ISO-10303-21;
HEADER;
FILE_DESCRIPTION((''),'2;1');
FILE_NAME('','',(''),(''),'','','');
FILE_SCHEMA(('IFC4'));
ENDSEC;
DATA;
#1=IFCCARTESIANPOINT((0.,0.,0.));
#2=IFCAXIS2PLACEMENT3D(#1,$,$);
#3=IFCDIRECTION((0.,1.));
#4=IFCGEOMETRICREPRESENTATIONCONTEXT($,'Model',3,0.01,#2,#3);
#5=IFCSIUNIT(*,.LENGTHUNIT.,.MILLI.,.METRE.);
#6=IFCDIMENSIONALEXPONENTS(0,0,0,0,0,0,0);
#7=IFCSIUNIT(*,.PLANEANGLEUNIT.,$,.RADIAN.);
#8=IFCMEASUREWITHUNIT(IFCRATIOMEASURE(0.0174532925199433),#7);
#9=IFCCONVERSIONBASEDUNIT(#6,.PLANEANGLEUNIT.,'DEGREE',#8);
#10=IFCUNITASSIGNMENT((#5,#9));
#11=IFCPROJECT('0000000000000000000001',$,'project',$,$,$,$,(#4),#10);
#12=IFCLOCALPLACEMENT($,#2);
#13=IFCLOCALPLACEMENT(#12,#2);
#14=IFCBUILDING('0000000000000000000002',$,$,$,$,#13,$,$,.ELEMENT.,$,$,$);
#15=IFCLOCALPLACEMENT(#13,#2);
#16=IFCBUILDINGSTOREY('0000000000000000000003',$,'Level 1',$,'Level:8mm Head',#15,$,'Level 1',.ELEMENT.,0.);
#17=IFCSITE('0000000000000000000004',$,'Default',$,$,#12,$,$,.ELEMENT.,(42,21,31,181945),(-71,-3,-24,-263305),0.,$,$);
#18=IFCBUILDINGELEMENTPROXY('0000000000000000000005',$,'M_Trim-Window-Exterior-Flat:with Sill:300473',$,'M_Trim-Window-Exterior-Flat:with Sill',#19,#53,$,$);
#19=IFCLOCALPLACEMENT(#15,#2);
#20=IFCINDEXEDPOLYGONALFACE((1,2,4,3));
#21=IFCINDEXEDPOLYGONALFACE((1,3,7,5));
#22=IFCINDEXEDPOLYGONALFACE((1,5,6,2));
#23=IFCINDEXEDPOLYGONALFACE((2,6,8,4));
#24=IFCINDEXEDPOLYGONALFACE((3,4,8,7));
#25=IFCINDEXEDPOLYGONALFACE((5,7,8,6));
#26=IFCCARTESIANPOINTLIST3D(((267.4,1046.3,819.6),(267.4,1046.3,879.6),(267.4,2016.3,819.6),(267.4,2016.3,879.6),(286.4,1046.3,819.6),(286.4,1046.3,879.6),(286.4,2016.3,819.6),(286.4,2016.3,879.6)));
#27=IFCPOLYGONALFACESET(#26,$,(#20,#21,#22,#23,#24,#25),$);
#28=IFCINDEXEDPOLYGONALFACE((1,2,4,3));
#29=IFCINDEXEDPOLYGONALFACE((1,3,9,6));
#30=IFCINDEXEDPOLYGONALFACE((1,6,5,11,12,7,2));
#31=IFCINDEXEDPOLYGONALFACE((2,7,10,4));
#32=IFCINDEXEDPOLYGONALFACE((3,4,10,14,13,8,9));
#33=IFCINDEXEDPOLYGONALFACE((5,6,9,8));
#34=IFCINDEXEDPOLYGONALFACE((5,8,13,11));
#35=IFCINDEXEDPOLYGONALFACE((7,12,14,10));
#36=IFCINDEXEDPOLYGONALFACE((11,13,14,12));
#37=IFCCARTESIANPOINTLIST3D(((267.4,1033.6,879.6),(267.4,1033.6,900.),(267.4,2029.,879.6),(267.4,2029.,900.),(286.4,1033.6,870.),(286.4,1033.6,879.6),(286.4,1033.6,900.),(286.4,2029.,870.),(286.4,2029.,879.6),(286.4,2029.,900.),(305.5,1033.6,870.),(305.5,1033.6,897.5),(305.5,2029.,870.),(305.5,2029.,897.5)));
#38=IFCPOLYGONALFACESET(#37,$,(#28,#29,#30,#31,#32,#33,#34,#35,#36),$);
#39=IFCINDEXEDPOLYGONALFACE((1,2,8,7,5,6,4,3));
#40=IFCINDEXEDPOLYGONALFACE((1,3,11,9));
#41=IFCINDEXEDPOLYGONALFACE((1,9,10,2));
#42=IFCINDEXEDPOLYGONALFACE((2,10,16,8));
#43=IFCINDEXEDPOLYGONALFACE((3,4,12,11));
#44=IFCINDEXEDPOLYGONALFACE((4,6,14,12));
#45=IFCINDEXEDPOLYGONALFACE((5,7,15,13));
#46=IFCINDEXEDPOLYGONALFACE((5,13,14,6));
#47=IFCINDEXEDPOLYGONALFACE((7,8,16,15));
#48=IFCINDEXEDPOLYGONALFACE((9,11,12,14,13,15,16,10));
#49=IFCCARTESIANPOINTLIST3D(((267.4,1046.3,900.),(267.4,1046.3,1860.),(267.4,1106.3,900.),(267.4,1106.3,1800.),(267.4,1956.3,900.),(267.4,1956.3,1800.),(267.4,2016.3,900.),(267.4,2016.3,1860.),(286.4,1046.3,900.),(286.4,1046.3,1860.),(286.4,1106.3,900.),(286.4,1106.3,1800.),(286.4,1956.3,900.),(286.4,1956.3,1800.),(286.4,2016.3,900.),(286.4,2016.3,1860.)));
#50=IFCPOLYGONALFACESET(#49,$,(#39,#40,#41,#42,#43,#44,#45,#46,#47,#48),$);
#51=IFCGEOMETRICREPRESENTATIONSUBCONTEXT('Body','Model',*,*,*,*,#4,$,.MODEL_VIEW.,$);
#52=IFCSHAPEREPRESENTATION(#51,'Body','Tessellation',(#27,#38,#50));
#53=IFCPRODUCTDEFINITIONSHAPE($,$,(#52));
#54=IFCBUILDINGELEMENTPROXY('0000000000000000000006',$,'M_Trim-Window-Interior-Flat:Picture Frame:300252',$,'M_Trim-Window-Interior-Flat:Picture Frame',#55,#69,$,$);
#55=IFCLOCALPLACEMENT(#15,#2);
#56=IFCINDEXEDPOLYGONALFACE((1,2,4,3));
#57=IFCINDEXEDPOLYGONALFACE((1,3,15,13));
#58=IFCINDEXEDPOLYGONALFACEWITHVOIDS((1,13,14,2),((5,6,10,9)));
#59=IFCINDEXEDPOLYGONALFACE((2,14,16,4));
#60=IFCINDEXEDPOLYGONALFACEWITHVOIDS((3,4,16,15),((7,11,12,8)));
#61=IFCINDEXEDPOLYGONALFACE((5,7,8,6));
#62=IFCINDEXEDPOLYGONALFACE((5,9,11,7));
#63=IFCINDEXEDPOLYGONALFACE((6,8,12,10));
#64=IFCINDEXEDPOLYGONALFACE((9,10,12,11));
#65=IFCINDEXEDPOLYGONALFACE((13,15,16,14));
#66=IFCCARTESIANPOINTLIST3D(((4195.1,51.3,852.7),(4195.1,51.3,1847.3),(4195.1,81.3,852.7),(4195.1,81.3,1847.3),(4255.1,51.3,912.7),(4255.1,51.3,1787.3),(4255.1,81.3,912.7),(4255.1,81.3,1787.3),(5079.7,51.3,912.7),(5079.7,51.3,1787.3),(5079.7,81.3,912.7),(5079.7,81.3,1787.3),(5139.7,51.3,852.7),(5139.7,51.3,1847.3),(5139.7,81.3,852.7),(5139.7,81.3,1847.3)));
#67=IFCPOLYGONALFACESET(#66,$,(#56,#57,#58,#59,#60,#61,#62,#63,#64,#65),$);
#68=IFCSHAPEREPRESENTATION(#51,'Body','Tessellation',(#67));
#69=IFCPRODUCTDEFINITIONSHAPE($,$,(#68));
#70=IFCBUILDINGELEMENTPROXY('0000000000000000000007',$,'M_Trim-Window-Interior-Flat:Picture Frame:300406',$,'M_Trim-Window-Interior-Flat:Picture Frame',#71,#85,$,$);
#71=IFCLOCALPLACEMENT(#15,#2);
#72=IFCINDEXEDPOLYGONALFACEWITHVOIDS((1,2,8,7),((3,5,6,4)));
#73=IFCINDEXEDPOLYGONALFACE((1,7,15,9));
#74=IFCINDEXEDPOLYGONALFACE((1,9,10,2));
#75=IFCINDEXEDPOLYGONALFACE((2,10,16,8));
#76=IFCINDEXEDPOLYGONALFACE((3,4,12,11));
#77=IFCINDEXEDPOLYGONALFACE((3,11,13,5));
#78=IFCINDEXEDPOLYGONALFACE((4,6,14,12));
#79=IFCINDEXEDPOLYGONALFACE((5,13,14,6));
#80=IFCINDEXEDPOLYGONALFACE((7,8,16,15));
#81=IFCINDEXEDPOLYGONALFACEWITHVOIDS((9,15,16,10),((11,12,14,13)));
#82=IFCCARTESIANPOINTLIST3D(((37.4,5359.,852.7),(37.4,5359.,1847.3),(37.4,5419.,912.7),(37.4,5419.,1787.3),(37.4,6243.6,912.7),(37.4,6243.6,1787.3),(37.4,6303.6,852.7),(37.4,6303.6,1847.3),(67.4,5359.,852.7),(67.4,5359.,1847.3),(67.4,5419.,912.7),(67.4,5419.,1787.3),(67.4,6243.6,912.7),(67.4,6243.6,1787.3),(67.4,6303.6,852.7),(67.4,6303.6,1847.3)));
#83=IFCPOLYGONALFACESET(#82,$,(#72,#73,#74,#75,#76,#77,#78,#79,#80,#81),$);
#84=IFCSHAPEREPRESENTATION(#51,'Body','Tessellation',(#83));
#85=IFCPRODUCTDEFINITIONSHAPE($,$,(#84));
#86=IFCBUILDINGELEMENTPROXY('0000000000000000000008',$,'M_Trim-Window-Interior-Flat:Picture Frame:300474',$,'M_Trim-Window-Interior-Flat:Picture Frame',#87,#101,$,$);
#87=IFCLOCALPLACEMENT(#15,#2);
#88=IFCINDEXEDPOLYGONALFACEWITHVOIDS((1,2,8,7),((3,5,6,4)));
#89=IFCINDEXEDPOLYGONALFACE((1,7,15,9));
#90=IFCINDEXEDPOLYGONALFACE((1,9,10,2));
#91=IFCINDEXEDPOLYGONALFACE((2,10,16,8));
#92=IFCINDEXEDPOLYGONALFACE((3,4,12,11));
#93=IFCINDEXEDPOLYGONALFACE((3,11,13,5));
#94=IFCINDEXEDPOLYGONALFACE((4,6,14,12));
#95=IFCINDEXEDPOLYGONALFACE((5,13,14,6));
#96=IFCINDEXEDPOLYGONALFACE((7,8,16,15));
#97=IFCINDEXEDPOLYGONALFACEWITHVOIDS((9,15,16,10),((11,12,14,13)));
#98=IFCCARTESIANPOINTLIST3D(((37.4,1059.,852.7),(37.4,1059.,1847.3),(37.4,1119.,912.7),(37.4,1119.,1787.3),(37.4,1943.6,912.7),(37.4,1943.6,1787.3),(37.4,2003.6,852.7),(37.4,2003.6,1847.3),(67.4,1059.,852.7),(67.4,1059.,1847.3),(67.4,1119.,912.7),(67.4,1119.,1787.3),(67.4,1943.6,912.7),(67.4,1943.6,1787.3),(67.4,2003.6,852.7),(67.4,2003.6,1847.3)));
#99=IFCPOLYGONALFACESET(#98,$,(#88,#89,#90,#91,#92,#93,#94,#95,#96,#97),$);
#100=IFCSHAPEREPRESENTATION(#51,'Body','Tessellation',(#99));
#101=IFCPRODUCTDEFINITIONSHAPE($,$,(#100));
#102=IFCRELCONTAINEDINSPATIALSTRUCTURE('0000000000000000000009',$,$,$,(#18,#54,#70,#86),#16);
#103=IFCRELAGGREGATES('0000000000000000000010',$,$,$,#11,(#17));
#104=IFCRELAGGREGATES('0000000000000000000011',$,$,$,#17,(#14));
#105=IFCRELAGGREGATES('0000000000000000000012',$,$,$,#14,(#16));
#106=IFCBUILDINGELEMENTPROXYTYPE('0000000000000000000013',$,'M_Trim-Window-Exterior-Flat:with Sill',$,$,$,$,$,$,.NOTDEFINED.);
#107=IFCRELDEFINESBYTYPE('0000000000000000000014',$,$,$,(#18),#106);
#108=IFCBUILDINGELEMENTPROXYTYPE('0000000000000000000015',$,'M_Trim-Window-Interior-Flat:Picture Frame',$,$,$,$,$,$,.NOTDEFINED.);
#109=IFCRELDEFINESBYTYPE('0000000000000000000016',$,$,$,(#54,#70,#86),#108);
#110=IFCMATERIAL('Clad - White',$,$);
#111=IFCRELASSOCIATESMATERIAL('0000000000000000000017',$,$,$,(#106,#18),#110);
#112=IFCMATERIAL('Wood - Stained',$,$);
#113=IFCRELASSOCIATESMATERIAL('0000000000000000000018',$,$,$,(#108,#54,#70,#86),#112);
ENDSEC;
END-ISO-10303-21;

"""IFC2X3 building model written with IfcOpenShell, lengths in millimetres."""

from ifc_helpers import new_model, entity, si_unit, converted_unit, direction, frame, frame_2d, origin, place, context, subcontext, project, spatial, polyline, rectangle, outline, extrude, source, transform, mapped, material, type_object, type_shapes, element, save


model = new_model("IFC2X3")

# Units and contexts
model_context = context("Model", 3, precision=0.01, world=origin(), true_north=direction((0.0, 1.0)))
body_context = subcontext(model_context, "Body", "Model", "MODEL_VIEW")
ifc_project = project(units=[si_unit("LENGTHUNIT", "METRE", prefix="MILLI"), converted_unit("PLANEANGLEUNIT", "DEGREE", entity("IfcRatioMeasure", 0.0174532925199433), si_unit("PLANEANGLEUNIT", "RADIAN"), dimensions=[0, 0, 0, 0, 0, 0, 0])], contexts=[model_context])

# Site, building, storey
site_placement = place(None, origin())
site = spatial("IfcSite", under=ifc_project, at=site_placement, Name="Default", CompositionType="ELEMENT", RefLatitude=(42, 21, 31, 181945), RefLongitude=(-71, -3, -24, -263305), RefElevation=0.0)
building_placement = place(site_placement, origin())
building = spatial("IfcBuilding", under=site, at=building_placement, CompositionType="ELEMENT")
storey_placement = place(building_placement, origin())
storey = spatial("IfcBuildingStorey", under=building, at=storey_placement, Name="Level 1", ObjectType="Level:8mm Head", LongName="Level 1", CompositionType="ELEMENT", Elevation=0.0)

# Building element proxies
ifc_material_1 = material(Name="Clad - White")
ifc_material_2 = material(Name="Wood - Stained")
building_element_proxy_type_1 = type_object("IfcBuildingElementProxyType", Name="M_Trim-Window-Exterior-Flat:with Sill", PredefinedType="NOTDEFINED", material=ifc_material_1)
shared_shape_1 = source(origin(), body_context, "Body", "SweptSolid", [
    extrude(rectangle(XDim=970.0, YDim=60.0, at=frame_2d((0.0, 0.0), x_axis=(1.0, 0.0))), frame((0.0, -950.4, 0.0), z_axis=(0.0, 0.0, 1.0), x_axis=(-1.0, 0.0, 0.0)), (0.0, 0.0, 1.0), 19.1),
    extrude(outline(polyline([(-19.0, -15.2), (0.0, -15.2), (0.0, -5.7), (19.0, -5.7), (19.0, 14.8), (0.0, 14.8), (-19.0, 12.3), (-19.0, -15.2)])), frame((-497.7, -914.8, 19.0), z_axis=(1.0, 0.0, 0.0), x_axis=(0.0, 0.0, -1.0)), (0.0, 0.0, 1.0), 995.4),
    extrude(outline(polyline([(-495.0, -485.0), (465.0, -485.0), (465.0, -425.0), (-435.0, -425.0), (-435.0, 425.0), (465.0, 425.0), (465.0, 485.0), (-495.0, 485.0), (-495.0, -485.0)])), frame((0.0, -435.0, 0.0), z_axis=(0.0, 0.0, 1.0), x_axis=(0.0, -1.0, 0.0)), (0.0, 0.0, 1.0), 19.1),
])
type_shapes(building_element_proxy_type_1, [shared_shape_1])
for number, where, z_axis, x_axis, name in (
    (1, (267.4, 1531.3, 1800.0), (1.0, 0.0, 0.0), (0.0, 1.0, 0.0), "M_Trim-Window-Exterior-Flat:with Sill:300473"),
):
    element("IfcBuildingElementProxy", number, at=place(storey_placement, frame(where, z_axis=z_axis, x_axis=x_axis)), inside=storey, type_object=building_element_proxy_type_1, material=ifc_material_1, Name=name, ObjectType="M_Trim-Window-Exterior-Flat:with Sill", context=body_context, shape_type="MappedRepresentation", body=[
        mapped(shared_shape_1, transform((0.0, 0.0, 0.0), scale=1.0)),
    ])
building_element_proxy_type_2 = type_object("IfcBuildingElementProxyType", Name="M_Trim-Window-Interior-Flat:Picture Frame", PredefinedType="NOTDEFINED", material=ifc_material_2)
shared_shape_2 = source(origin(), body_context, "Body", "SweptSolid", [
    extrude(outline(polyline([(-472.3, -497.3), (472.3, -497.3), (472.3, 497.3), (-472.3, 497.3), (-472.3, -497.3)]), holes=[polyline([(-412.3, -437.3), (-412.3, 437.3), (412.3, 437.3), (412.3, -437.3), (-412.3, -437.3)])]), frame((0.0, -450.0, 0.0), z_axis=(0.0, 0.0, 1.0), x_axis=(-1.0, 0.0, 0.0)), (0.0, 0.0, 1.0), 30.0),
])
type_shapes(building_element_proxy_type_2, [shared_shape_2])
for number, where, z_axis, x_axis, name in (
    (2, (4667.4, 81.3, 1800.0), (0.0, -1.0, 0.0), (1.0, 0.0, 0.0), "M_Trim-Window-Interior-Flat:Picture Frame:300252"),
    (3, (67.4, 5831.3, 1800.0), (-1.0, 0.0, 0.0), (0.0, -1.0, 0.0), "M_Trim-Window-Interior-Flat:Picture Frame:300406"),
    (4, (67.4, 1531.3, 1800.0), (-1.0, 0.0, 0.0), (0.0, -1.0, 0.0), "M_Trim-Window-Interior-Flat:Picture Frame:300474"),
):
    element("IfcBuildingElementProxy", number, at=place(storey_placement, frame(where, z_axis=z_axis, x_axis=x_axis)), inside=storey, type_object=building_element_proxy_type_2, material=ifc_material_2, Name=name, ObjectType="M_Trim-Window-Interior-Flat:Picture Frame", context=body_context, shape_type="MappedRepresentation", body=[
        mapped(shared_shape_2, transform((0.0, 0.0, 0.0), scale=1.0)),
    ])

save(model, "model.ifc")
